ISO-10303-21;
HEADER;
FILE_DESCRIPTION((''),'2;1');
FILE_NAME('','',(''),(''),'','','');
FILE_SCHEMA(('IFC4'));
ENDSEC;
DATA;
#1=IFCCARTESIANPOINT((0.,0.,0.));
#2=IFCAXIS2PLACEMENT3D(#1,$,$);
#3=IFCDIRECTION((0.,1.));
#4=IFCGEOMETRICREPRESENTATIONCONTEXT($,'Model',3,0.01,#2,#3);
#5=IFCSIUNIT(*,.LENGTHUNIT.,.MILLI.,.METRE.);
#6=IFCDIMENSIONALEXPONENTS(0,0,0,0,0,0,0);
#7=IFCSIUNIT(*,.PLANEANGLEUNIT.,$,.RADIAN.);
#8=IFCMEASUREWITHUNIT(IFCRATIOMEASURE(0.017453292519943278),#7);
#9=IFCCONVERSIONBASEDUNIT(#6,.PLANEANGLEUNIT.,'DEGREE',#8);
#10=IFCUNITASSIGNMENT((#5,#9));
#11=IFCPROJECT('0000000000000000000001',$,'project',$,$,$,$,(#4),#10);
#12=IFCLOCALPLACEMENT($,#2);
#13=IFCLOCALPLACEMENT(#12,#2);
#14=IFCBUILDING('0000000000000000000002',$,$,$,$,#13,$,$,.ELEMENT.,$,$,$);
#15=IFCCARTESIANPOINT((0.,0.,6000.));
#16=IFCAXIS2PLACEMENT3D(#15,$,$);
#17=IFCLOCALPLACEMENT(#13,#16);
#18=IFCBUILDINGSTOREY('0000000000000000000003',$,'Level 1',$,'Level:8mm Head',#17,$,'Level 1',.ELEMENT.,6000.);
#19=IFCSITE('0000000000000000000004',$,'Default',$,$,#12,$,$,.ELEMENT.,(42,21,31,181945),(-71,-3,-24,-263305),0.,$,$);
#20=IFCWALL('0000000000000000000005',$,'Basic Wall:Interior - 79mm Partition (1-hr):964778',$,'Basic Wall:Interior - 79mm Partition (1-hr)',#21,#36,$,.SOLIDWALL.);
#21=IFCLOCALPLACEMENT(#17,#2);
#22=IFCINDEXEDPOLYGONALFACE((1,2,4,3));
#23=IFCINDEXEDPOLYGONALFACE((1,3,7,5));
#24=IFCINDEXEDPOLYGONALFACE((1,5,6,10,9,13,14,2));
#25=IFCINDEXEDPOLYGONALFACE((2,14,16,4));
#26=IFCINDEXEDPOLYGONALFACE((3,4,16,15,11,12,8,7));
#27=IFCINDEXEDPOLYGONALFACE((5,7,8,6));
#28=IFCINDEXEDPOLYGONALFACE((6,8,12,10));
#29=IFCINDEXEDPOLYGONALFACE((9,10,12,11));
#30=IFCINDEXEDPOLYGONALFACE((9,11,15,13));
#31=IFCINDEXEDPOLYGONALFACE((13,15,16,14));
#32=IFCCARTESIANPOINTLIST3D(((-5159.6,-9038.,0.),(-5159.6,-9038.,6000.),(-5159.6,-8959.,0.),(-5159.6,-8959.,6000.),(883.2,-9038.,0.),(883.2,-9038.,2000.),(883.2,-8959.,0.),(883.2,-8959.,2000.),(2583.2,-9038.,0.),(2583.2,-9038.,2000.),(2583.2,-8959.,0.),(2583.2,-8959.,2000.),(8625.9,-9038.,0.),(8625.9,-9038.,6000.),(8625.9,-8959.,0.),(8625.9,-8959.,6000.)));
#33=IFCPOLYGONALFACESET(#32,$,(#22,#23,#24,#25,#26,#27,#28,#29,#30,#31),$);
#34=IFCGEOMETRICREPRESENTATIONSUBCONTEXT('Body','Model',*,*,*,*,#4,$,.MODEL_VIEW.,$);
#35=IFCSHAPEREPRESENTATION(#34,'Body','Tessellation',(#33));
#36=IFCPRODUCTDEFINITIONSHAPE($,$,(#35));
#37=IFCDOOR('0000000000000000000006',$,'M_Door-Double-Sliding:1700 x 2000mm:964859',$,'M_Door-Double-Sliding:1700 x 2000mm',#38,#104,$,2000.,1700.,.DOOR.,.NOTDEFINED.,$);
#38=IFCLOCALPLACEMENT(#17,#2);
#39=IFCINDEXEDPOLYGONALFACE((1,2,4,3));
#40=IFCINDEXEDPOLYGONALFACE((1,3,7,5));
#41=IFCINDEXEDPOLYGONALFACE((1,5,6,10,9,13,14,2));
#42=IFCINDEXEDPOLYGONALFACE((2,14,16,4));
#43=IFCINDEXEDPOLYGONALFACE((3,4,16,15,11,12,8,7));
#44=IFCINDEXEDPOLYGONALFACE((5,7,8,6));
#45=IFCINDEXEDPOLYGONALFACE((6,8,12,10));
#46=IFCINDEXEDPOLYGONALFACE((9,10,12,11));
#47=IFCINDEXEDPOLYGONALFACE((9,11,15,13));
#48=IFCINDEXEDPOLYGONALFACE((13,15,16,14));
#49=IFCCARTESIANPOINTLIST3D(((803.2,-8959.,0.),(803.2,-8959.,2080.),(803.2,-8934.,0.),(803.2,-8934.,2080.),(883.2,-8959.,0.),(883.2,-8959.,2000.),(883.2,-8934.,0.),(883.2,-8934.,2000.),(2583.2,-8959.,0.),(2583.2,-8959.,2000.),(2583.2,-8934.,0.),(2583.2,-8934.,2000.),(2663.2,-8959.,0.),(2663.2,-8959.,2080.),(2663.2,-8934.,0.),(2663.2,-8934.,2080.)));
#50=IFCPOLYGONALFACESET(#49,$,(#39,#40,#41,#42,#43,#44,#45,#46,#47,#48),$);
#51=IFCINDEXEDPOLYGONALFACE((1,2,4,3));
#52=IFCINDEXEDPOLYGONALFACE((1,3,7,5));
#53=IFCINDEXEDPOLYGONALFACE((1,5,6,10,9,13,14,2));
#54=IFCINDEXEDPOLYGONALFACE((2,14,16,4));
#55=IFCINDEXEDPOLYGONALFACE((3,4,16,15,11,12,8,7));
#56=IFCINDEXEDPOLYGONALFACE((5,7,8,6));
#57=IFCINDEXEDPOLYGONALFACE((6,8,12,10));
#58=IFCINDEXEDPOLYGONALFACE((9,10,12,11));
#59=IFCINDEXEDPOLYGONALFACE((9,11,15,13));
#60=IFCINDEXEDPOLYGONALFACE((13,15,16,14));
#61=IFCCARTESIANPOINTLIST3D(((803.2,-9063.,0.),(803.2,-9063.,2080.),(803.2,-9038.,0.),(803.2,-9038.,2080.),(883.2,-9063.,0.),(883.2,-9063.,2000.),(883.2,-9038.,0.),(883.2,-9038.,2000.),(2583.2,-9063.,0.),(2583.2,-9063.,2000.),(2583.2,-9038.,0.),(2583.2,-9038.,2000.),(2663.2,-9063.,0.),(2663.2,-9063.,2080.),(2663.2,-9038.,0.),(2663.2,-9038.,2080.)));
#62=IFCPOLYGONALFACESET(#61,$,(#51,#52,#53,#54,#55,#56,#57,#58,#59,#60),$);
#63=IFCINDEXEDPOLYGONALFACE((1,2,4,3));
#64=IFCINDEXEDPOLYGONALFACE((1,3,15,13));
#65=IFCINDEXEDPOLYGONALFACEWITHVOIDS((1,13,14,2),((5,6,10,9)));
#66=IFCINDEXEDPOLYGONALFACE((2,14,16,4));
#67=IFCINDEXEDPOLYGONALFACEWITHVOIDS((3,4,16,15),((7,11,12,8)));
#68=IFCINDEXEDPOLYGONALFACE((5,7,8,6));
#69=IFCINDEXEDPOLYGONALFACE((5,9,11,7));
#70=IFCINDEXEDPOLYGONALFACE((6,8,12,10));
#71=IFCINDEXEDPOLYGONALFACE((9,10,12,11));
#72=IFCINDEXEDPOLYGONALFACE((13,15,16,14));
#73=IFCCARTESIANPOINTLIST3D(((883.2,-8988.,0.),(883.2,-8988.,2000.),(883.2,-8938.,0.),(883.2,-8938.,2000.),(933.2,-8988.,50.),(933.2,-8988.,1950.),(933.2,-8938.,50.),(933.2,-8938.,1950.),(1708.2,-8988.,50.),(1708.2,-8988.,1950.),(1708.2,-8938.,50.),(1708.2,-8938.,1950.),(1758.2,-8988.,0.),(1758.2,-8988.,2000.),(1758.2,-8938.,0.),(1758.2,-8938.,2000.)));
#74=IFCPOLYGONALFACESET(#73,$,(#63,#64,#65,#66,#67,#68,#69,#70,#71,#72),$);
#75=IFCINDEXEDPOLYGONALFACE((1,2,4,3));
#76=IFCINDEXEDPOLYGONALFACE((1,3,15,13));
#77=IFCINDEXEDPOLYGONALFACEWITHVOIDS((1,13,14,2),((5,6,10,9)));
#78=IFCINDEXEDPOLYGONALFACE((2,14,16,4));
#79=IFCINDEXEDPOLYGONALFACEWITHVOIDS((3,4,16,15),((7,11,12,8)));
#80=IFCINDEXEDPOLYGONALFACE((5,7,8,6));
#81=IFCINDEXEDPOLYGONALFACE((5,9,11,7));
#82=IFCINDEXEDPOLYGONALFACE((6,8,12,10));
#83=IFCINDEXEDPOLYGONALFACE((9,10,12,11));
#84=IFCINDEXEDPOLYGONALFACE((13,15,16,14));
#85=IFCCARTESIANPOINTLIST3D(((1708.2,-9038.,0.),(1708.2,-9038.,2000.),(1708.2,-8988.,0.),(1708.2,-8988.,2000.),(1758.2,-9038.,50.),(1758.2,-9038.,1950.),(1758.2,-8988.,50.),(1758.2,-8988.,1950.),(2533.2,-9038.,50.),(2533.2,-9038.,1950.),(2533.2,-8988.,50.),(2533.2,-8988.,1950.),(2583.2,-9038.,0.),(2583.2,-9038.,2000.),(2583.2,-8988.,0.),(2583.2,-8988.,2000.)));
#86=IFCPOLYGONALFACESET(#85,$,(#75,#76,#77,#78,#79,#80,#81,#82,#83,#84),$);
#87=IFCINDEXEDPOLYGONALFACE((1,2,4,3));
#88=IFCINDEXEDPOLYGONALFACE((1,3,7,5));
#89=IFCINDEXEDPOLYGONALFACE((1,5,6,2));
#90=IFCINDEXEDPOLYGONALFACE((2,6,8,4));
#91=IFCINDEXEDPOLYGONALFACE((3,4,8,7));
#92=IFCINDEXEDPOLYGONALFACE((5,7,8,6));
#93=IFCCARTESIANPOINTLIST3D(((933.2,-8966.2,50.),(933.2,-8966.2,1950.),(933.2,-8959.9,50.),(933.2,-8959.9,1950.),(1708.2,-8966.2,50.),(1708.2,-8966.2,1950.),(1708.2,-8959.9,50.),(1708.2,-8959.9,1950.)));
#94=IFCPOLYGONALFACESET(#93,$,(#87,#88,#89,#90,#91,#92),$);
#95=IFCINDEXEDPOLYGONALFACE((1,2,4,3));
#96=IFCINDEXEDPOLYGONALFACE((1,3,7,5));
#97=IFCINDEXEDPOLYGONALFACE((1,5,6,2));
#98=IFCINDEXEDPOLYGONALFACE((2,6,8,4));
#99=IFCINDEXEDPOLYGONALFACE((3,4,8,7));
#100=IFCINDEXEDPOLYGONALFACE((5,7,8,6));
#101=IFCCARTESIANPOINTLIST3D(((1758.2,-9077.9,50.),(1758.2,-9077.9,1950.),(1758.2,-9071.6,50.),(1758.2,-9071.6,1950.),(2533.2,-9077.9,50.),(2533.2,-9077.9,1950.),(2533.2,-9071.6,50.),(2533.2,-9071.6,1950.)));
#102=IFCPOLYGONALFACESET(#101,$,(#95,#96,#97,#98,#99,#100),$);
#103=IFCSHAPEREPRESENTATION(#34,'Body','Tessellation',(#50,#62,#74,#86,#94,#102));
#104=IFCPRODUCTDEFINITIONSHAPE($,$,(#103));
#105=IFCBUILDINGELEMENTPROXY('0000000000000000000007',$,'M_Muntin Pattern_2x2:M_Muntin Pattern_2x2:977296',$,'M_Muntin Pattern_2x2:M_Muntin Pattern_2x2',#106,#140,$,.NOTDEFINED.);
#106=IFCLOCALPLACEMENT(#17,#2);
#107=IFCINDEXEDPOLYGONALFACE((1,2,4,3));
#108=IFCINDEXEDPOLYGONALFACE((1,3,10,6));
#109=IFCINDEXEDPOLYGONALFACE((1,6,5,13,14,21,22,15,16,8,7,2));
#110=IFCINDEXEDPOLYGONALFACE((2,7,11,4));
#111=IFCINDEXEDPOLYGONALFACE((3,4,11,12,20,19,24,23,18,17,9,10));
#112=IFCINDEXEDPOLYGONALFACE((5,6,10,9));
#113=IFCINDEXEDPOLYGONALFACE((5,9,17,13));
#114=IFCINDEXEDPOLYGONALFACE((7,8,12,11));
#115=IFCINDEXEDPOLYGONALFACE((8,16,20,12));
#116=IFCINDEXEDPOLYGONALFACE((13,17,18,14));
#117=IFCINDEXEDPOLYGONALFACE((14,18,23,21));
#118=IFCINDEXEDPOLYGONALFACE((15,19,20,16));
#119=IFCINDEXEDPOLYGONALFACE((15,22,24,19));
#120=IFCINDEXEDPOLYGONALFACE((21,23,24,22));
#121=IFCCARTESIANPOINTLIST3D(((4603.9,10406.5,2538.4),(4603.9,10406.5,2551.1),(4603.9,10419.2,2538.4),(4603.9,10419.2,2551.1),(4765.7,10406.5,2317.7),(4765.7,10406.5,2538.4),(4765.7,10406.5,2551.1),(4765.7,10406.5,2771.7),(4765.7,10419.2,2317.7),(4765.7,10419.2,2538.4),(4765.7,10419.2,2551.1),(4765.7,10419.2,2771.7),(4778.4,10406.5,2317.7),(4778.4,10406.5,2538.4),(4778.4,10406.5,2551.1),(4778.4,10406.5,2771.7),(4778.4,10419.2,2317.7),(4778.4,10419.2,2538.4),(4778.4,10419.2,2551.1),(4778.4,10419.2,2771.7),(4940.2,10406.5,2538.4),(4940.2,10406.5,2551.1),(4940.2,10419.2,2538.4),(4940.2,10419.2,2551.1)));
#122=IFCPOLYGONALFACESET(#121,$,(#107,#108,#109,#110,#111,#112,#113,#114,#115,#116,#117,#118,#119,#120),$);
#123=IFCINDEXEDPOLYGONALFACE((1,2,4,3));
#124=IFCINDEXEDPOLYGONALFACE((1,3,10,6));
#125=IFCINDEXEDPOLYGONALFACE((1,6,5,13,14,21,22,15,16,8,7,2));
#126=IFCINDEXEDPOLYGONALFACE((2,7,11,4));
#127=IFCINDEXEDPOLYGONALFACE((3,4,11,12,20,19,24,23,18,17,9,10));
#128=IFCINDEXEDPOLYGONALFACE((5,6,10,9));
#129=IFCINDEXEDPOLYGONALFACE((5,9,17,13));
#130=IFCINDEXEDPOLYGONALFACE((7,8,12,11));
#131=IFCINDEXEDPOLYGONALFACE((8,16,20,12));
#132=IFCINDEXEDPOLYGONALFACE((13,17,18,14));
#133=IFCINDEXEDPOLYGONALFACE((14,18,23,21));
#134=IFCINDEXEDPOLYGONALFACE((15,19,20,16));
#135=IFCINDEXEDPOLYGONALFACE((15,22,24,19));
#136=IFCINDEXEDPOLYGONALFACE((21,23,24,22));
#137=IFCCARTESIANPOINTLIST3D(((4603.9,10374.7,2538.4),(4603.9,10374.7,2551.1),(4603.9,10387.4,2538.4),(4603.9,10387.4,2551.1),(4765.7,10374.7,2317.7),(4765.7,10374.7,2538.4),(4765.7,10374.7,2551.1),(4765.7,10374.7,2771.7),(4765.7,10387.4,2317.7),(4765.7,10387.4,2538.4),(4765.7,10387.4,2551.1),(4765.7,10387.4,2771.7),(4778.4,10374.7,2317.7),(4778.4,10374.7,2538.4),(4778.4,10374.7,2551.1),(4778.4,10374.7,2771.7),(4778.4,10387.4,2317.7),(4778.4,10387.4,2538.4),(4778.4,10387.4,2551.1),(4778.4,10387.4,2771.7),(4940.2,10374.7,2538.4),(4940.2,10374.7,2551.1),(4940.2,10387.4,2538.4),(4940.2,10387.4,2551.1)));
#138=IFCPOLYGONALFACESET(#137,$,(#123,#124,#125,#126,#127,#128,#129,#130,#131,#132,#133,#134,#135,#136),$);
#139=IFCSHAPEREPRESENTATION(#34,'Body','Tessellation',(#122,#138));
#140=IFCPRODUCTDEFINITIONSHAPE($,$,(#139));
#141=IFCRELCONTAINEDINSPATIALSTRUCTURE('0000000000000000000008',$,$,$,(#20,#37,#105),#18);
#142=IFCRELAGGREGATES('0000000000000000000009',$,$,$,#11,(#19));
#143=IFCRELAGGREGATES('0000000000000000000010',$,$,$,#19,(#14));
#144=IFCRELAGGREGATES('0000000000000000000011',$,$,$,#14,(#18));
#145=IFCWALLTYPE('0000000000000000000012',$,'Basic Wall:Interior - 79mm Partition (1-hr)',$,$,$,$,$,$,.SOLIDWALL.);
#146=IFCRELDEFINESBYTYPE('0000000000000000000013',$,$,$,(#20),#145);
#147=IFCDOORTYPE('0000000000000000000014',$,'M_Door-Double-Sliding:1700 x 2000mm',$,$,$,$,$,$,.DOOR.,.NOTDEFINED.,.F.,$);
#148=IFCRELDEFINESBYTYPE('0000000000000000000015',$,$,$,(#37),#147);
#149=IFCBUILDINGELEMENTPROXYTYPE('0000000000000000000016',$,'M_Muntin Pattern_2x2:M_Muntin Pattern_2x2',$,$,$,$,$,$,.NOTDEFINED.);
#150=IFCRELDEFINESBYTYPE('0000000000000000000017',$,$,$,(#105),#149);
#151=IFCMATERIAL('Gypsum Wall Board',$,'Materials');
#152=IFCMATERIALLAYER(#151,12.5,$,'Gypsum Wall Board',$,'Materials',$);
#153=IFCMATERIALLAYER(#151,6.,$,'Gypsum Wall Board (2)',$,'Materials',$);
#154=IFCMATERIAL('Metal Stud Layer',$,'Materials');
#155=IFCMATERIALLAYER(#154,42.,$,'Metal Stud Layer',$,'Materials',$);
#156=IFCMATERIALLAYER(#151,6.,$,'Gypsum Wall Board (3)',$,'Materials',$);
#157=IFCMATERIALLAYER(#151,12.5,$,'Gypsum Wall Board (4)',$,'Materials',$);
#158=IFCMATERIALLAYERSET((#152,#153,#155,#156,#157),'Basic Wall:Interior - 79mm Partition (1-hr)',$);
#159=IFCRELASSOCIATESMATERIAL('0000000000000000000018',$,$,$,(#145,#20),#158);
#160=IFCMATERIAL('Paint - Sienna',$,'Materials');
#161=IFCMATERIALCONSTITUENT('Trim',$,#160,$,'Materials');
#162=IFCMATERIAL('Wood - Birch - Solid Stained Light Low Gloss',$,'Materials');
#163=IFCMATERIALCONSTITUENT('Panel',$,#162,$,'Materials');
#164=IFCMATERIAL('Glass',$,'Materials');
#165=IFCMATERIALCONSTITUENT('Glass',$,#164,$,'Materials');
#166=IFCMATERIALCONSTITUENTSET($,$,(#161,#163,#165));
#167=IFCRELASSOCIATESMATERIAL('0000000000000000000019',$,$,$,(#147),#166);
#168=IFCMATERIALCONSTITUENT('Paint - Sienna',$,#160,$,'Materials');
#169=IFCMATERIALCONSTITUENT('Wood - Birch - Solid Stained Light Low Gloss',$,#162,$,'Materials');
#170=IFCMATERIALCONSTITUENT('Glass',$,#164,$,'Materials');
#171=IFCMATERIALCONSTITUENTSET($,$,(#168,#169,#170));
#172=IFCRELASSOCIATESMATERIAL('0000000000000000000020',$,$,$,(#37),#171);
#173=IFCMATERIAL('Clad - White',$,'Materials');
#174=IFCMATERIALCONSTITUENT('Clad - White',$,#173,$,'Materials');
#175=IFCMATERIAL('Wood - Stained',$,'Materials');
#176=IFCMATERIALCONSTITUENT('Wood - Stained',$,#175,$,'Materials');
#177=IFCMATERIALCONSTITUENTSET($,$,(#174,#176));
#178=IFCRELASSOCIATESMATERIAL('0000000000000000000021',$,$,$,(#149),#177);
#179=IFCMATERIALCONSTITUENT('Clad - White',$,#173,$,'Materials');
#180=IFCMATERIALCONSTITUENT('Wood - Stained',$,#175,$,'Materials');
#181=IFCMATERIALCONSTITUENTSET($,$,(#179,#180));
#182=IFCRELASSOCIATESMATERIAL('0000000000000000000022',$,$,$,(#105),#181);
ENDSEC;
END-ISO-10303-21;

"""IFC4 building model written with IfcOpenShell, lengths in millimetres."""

from ifc_helpers import new_model, entity, si_unit, converted_unit, direction, frame, frame_2d, origin, origin_2d_with_axis, place, context, subcontext, project, spatial, polyline, rectangle, outline, extrude, source, transform, mapped, material, layer, layer_set, layer_usage, constituent, constituent_set, type_object, type_shapes, element, fill, save


model = new_model("IFC4")

# Units and contexts
model_context = context("Model", 3, precision=0.01, world=origin(), true_north=direction((0.0, 1.0)))
body_context = subcontext(model_context, "Body", "Model", "MODEL_VIEW")
ifc_project = project(units=[si_unit("LENGTHUNIT", "METRE", prefix="MILLI"), converted_unit("PLANEANGLEUNIT", "DEGREE", entity("IfcRatioMeasure", 0.017453292519943278), si_unit("PLANEANGLEUNIT", "RADIAN"), dimensions=[0, 0, 0, 0, 0, 0, 0])], contexts=[model_context])

# Site, building, storey
site_placement = place(None, origin())
site = spatial("IfcSite", under=ifc_project, at=site_placement, Name="Default", CompositionType="ELEMENT", RefLatitude=(42, 21, 31, 181945), RefLongitude=(-71, -3, -24, -263305), RefElevation=0.0)
building_placement = place(site_placement, origin())
building = spatial("IfcBuilding", under=site, at=building_placement, CompositionType="ELEMENT")
storey_placement = place(building_placement, frame((0.0, 0.0, 6000.0)))
storey = spatial("IfcBuildingStorey", under=building, at=storey_placement, Name="Level 1", ObjectType="Level:8mm Head", LongName="Level 1", CompositionType="ELEMENT", Elevation=6000.0)

# Shared definitions
ifc_material_1 = material(Name="Gypsum Wall Board", Category="Materials")
ifc_layer_1 = layer(ifc_material_1, 12.5, Name="Gypsum Wall Board", Category="Materials")
ifc_layer_2 = layer(ifc_material_1, 6.0, Name="Gypsum Wall Board (2)", Category="Materials")
ifc_material_2 = material(Name="Metal Stud Layer", Category="Materials")
ifc_layer_3 = layer(ifc_material_2, 42.0, Name="Metal Stud Layer", Category="Materials")
ifc_layer_4 = layer(ifc_material_1, 6.0, Name="Gypsum Wall Board (3)", Category="Materials")
ifc_layer_5 = layer(ifc_material_1, 12.5, Name="Gypsum Wall Board (4)", Category="Materials")
ifc_layer_set_1 = layer_set([ifc_layer_1, ifc_layer_2, ifc_layer_3, ifc_layer_4, ifc_layer_5], Name="Basic Wall:Interior - 79mm Partition (1-hr)")
ifc_layer_usage_1 = layer_usage(ifc_layer_set_1, "AXIS2", "NEGATIVE", 39.5)
wall_type = type_object("IfcWallType", Name="Basic Wall:Interior - 79mm Partition (1-hr)", PredefinedType="SOLIDWALL", material=ifc_layer_set_1)

# Wall, opening, door
ifc_material_3 = material(Name="Paint - Sienna", Category="Materials")
ifc_material_4 = material(Name="Wood - Birch - Solid Stained Light Low Gloss", Category="Materials")
ifc_material_5 = material(Name="Glass", Category="Materials")
ifc_constituent_1 = constituent(ifc_material_3, Name="Trim", Category="Materials")
ifc_constituent_2 = constituent(ifc_material_4, Name="Panel", Category="Materials")
ifc_constituent_3 = constituent(ifc_material_5, Name="Glass", Category="Materials")
ifc_constituent_set_1 = constituent_set(constituents=[ifc_constituent_1, ifc_constituent_2, ifc_constituent_3])
door_type = type_object("IfcDoorType", Name="M_Door-Double-Sliding:1700 x 2000mm", OperationType="NOTDEFINED", ParameterTakesPrecedence=False, PredefinedType="DOOR", material=ifc_constituent_set_1)
shared_shape_1 = source(origin(), body_context, "Body", "SweptSolid", [
    extrude(outline(polyline([(-1020.0, -930.0), (1060.0, -930.0), (1060.0, 930.0), (-1020.0, 930.0), (-1020.0, 850.0), (980.0, 850.0), (980.0, -850.0), (-1020.0, -850.0), (-1020.0, -930.0)])), frame((850.0, -25.0, 1020.0), z_axis=(0.0, 1.0, 0.0), x_axis=(0.0, 0.0, 1.0)), (0.0, 0.0, 1.0), 25.0),
    extrude(outline(polyline([(-930.0, -1020.0), (-850.0, -1020.0), (-850.0, 980.0), (850.0, 980.0), (850.0, -1020.0), (930.0, -1020.0), (930.0, 1060.0), (-930.0, 1060.0), (-930.0, -1020.0)])), frame((850.0, 79.0, 1020.0), z_axis=(0.0, 1.0, 0.0), x_axis=(-1.0, 0.0, 0.0)), (0.0, 0.0, 1.0), 25.0),
    extrude(outline(polyline([(-437.5, -1000.0), (437.5, -1000.0), (437.5, 1000.0), (-437.5, 1000.0), (-437.5, -1000.0)]), holes=[polyline([(-387.5, -950.0), (-387.5, 950.0), (387.5, 950.0), (387.5, -950.0), (-387.5, -950.0)])]), frame((1262.5, -21.0, 1000.0), z_axis=(0.0, 1.0, 0.0), x_axis=(1.0, 0.0, 0.0)), (0.0, 0.0, 1.0), 50.0),
    extrude(outline(polyline([(-1000.0, -437.5), (1000.0, -437.5), (1000.0, 437.5), (-1000.0, 437.5), (-1000.0, -437.5)]), holes=[polyline([(-950.0, -387.5), (-950.0, 387.5), (950.0, 387.5), (950.0, -387.5), (-950.0, -387.5)])]), frame((437.5, 29.0, 1000.0), z_axis=(0.0, 1.0, 0.0), x_axis=(0.0, 0.0, -1.0)), (0.0, 0.0, 1.0), 50.0),
    extrude(rectangle(XDim=6.3, YDim=775.0, at=frame_2d((0.0, 0.0), x_axis=(1.0, 0.0))), frame((1262.5, 4.0, 50.0), z_axis=(0.0, 0.0, 1.0), x_axis=(0.0, -1.0, 0.0)), (0.0, 0.0, 1.0), 1900.0),
    extrude(rectangle(XDim=6.4, YDim=775.0, at=origin_2d_with_axis()), frame((437.5, 115.7, 50.0), z_axis=(0.0, 0.0, 1.0), x_axis=(0.0, 1.0, 0.0)), (0.0, 0.0, 1.0), 1900.0),
])
type_shapes(door_type, [shared_shape_1])
wall_1_placement = place(storey_placement, frame((-5159.6, -8998.5, 0.0)))
wall_1 = element("IfcWall", 1, at=wall_1_placement, inside=storey, type_object=wall_type, material=ifc_layer_usage_1, Name="Basic Wall:Interior - 79mm Partition (1-hr):964778", ObjectType="Basic Wall:Interior - 79mm Partition (1-hr)", PredefinedType="SOLIDWALL", context=body_context, shape_type="SweptSolid", body=[
    extrude(rectangle(XDim=13785.5, YDim=79.0, at=frame_2d((6892.8, 0.0), x_axis=(1.0, 0.0))), origin(), (0.0, 0.0, 1.0), 6000.0),
])
opening_1_placement = place(wall_1_placement, frame((7742.8, 39.5, 0.0)))
opening_1 = element("IfcOpeningElement", 2, at=opening_1_placement, cuts=wall_1, PredefinedType="OPENING", context=body_context, shape_type="SweptSolid", body=[
    extrude(rectangle(XDim=2000.0, YDim=1700.0, at=frame_2d((1000.0, 850.0), x_axis=(-1.0, 0.0))), frame((0.0, 0.0, 0.0), z_axis=(0.0, -1.0, 0.0), x_axis=(0.0, 0.0, 1.0)), (0.0, 0.0, 1.0), 79.0),
])
ifc_constituent_4 = constituent(ifc_material_3, Name="Paint - Sienna", Category="Materials")
ifc_constituent_5 = constituent(ifc_material_4, Name="Wood - Birch - Solid Stained Light Low Gloss", Category="Materials")
ifc_constituent_6 = constituent(ifc_material_5, Name="Glass", Category="Materials")
ifc_constituent_set_2 = constituent_set(constituents=[ifc_constituent_4, ifc_constituent_5, ifc_constituent_6])
door_1_placement = place(opening_1_placement, frame((0.0, 0.0, 0.0), z_axis=(0.0, 0.0, 1.0), x_axis=(-1.0, 0.0, 0.0)))
door_1 = element("IfcDoor", 3, at=door_1_placement, inside=storey, type_object=door_type, material=ifc_constituent_set_2, Name="M_Door-Double-Sliding:1700 x 2000mm:964859", ObjectType="M_Door-Double-Sliding:1700 x 2000mm", OperationType="NOTDEFINED", OverallHeight=2000.0, OverallWidth=1700.0, PredefinedType="DOOR", context=body_context, shape_type="MappedRepresentation", body=[
    mapped(shared_shape_1, transform((0.0, 0.0, 0.0), scale=1.0)),
])
fill(opening_1, door_1)

# Building element proxy
ifc_material_6 = material(Name="Clad - White", Category="Materials")
ifc_constituent_7 = constituent(ifc_material_6, Name="Clad - White", Category="Materials")
ifc_material_7 = material(Name="Wood - Stained", Category="Materials")
ifc_constituent_8 = constituent(ifc_material_7, Name="Wood - Stained", Category="Materials")
ifc_constituent_set_3 = constituent_set(constituents=[ifc_constituent_7, ifc_constituent_8])
ifc_constituent_9 = constituent(ifc_material_6, Name="Clad - White", Category="Materials")
ifc_constituent_10 = constituent(ifc_material_7, Name="Wood - Stained", Category="Materials")
ifc_constituent_set_4 = constituent_set(constituents=[ifc_constituent_9, ifc_constituent_10])
building_element_proxy_type_1 = type_object("IfcBuildingElementProxyType", Name="M_Muntin Pattern_2x2:M_Muntin Pattern_2x2", PredefinedType="NOTDEFINED", material=ifc_constituent_set_4)
shared_shape_2 = source(origin(), body_context, "Body", "SweptSolid", [
    extrude(outline(polyline([(6.4, -6.4), (227.0, -6.4), (227.0, 6.3), (6.4, 6.3), (6.4, 168.2), (-6.3, 168.2), (-6.3, 6.3), (-227.0, 6.3), (-227.0, -6.4), (-6.3, -6.4), (-6.3, -168.1), (6.4, -168.1), (6.4, -6.4)])), frame((0.0, 9.5, 227.0), z_axis=(0.0, 1.0, 0.0), x_axis=(0.0, 0.0, 1.0)), (0.0, 0.0, 1.0), 12.7),
    extrude(outline(polyline([(6.4, -6.4), (227.0, -6.4), (227.0, 6.3), (6.4, 6.3), (6.4, 168.2), (-6.3, 168.2), (-6.3, 6.3), (-227.0, 6.3), (-227.0, -6.4), (-6.3, -6.4), (-6.3, -168.1), (6.4, -168.1), (6.4, -6.4)])), frame((0.0, -22.2, 227.0), z_axis=(0.0, 1.0, 0.0), x_axis=(0.0, 0.0, 1.0)), (0.0, 0.0, 1.0), 12.7),
])
type_shapes(building_element_proxy_type_1, [shared_shape_2])
proxy_1_placement = place(storey_placement, frame((4772.1, 10396.9, 2317.7)))
element("IfcBuildingElementProxy", 4, at=proxy_1_placement, inside=storey, type_object=building_element_proxy_type_1, material=ifc_constituent_set_3, Name="M_Muntin Pattern_2x2:M_Muntin Pattern_2x2:977296", ObjectType="M_Muntin Pattern_2x2:M_Muntin Pattern_2x2", PredefinedType="NOTDEFINED", context=body_context, shape_type="MappedRepresentation", body=[
    mapped(shared_shape_2, transform((0.0, 0.0, 0.0), scale=1.0)),
])

save(model, "model.ifc")
